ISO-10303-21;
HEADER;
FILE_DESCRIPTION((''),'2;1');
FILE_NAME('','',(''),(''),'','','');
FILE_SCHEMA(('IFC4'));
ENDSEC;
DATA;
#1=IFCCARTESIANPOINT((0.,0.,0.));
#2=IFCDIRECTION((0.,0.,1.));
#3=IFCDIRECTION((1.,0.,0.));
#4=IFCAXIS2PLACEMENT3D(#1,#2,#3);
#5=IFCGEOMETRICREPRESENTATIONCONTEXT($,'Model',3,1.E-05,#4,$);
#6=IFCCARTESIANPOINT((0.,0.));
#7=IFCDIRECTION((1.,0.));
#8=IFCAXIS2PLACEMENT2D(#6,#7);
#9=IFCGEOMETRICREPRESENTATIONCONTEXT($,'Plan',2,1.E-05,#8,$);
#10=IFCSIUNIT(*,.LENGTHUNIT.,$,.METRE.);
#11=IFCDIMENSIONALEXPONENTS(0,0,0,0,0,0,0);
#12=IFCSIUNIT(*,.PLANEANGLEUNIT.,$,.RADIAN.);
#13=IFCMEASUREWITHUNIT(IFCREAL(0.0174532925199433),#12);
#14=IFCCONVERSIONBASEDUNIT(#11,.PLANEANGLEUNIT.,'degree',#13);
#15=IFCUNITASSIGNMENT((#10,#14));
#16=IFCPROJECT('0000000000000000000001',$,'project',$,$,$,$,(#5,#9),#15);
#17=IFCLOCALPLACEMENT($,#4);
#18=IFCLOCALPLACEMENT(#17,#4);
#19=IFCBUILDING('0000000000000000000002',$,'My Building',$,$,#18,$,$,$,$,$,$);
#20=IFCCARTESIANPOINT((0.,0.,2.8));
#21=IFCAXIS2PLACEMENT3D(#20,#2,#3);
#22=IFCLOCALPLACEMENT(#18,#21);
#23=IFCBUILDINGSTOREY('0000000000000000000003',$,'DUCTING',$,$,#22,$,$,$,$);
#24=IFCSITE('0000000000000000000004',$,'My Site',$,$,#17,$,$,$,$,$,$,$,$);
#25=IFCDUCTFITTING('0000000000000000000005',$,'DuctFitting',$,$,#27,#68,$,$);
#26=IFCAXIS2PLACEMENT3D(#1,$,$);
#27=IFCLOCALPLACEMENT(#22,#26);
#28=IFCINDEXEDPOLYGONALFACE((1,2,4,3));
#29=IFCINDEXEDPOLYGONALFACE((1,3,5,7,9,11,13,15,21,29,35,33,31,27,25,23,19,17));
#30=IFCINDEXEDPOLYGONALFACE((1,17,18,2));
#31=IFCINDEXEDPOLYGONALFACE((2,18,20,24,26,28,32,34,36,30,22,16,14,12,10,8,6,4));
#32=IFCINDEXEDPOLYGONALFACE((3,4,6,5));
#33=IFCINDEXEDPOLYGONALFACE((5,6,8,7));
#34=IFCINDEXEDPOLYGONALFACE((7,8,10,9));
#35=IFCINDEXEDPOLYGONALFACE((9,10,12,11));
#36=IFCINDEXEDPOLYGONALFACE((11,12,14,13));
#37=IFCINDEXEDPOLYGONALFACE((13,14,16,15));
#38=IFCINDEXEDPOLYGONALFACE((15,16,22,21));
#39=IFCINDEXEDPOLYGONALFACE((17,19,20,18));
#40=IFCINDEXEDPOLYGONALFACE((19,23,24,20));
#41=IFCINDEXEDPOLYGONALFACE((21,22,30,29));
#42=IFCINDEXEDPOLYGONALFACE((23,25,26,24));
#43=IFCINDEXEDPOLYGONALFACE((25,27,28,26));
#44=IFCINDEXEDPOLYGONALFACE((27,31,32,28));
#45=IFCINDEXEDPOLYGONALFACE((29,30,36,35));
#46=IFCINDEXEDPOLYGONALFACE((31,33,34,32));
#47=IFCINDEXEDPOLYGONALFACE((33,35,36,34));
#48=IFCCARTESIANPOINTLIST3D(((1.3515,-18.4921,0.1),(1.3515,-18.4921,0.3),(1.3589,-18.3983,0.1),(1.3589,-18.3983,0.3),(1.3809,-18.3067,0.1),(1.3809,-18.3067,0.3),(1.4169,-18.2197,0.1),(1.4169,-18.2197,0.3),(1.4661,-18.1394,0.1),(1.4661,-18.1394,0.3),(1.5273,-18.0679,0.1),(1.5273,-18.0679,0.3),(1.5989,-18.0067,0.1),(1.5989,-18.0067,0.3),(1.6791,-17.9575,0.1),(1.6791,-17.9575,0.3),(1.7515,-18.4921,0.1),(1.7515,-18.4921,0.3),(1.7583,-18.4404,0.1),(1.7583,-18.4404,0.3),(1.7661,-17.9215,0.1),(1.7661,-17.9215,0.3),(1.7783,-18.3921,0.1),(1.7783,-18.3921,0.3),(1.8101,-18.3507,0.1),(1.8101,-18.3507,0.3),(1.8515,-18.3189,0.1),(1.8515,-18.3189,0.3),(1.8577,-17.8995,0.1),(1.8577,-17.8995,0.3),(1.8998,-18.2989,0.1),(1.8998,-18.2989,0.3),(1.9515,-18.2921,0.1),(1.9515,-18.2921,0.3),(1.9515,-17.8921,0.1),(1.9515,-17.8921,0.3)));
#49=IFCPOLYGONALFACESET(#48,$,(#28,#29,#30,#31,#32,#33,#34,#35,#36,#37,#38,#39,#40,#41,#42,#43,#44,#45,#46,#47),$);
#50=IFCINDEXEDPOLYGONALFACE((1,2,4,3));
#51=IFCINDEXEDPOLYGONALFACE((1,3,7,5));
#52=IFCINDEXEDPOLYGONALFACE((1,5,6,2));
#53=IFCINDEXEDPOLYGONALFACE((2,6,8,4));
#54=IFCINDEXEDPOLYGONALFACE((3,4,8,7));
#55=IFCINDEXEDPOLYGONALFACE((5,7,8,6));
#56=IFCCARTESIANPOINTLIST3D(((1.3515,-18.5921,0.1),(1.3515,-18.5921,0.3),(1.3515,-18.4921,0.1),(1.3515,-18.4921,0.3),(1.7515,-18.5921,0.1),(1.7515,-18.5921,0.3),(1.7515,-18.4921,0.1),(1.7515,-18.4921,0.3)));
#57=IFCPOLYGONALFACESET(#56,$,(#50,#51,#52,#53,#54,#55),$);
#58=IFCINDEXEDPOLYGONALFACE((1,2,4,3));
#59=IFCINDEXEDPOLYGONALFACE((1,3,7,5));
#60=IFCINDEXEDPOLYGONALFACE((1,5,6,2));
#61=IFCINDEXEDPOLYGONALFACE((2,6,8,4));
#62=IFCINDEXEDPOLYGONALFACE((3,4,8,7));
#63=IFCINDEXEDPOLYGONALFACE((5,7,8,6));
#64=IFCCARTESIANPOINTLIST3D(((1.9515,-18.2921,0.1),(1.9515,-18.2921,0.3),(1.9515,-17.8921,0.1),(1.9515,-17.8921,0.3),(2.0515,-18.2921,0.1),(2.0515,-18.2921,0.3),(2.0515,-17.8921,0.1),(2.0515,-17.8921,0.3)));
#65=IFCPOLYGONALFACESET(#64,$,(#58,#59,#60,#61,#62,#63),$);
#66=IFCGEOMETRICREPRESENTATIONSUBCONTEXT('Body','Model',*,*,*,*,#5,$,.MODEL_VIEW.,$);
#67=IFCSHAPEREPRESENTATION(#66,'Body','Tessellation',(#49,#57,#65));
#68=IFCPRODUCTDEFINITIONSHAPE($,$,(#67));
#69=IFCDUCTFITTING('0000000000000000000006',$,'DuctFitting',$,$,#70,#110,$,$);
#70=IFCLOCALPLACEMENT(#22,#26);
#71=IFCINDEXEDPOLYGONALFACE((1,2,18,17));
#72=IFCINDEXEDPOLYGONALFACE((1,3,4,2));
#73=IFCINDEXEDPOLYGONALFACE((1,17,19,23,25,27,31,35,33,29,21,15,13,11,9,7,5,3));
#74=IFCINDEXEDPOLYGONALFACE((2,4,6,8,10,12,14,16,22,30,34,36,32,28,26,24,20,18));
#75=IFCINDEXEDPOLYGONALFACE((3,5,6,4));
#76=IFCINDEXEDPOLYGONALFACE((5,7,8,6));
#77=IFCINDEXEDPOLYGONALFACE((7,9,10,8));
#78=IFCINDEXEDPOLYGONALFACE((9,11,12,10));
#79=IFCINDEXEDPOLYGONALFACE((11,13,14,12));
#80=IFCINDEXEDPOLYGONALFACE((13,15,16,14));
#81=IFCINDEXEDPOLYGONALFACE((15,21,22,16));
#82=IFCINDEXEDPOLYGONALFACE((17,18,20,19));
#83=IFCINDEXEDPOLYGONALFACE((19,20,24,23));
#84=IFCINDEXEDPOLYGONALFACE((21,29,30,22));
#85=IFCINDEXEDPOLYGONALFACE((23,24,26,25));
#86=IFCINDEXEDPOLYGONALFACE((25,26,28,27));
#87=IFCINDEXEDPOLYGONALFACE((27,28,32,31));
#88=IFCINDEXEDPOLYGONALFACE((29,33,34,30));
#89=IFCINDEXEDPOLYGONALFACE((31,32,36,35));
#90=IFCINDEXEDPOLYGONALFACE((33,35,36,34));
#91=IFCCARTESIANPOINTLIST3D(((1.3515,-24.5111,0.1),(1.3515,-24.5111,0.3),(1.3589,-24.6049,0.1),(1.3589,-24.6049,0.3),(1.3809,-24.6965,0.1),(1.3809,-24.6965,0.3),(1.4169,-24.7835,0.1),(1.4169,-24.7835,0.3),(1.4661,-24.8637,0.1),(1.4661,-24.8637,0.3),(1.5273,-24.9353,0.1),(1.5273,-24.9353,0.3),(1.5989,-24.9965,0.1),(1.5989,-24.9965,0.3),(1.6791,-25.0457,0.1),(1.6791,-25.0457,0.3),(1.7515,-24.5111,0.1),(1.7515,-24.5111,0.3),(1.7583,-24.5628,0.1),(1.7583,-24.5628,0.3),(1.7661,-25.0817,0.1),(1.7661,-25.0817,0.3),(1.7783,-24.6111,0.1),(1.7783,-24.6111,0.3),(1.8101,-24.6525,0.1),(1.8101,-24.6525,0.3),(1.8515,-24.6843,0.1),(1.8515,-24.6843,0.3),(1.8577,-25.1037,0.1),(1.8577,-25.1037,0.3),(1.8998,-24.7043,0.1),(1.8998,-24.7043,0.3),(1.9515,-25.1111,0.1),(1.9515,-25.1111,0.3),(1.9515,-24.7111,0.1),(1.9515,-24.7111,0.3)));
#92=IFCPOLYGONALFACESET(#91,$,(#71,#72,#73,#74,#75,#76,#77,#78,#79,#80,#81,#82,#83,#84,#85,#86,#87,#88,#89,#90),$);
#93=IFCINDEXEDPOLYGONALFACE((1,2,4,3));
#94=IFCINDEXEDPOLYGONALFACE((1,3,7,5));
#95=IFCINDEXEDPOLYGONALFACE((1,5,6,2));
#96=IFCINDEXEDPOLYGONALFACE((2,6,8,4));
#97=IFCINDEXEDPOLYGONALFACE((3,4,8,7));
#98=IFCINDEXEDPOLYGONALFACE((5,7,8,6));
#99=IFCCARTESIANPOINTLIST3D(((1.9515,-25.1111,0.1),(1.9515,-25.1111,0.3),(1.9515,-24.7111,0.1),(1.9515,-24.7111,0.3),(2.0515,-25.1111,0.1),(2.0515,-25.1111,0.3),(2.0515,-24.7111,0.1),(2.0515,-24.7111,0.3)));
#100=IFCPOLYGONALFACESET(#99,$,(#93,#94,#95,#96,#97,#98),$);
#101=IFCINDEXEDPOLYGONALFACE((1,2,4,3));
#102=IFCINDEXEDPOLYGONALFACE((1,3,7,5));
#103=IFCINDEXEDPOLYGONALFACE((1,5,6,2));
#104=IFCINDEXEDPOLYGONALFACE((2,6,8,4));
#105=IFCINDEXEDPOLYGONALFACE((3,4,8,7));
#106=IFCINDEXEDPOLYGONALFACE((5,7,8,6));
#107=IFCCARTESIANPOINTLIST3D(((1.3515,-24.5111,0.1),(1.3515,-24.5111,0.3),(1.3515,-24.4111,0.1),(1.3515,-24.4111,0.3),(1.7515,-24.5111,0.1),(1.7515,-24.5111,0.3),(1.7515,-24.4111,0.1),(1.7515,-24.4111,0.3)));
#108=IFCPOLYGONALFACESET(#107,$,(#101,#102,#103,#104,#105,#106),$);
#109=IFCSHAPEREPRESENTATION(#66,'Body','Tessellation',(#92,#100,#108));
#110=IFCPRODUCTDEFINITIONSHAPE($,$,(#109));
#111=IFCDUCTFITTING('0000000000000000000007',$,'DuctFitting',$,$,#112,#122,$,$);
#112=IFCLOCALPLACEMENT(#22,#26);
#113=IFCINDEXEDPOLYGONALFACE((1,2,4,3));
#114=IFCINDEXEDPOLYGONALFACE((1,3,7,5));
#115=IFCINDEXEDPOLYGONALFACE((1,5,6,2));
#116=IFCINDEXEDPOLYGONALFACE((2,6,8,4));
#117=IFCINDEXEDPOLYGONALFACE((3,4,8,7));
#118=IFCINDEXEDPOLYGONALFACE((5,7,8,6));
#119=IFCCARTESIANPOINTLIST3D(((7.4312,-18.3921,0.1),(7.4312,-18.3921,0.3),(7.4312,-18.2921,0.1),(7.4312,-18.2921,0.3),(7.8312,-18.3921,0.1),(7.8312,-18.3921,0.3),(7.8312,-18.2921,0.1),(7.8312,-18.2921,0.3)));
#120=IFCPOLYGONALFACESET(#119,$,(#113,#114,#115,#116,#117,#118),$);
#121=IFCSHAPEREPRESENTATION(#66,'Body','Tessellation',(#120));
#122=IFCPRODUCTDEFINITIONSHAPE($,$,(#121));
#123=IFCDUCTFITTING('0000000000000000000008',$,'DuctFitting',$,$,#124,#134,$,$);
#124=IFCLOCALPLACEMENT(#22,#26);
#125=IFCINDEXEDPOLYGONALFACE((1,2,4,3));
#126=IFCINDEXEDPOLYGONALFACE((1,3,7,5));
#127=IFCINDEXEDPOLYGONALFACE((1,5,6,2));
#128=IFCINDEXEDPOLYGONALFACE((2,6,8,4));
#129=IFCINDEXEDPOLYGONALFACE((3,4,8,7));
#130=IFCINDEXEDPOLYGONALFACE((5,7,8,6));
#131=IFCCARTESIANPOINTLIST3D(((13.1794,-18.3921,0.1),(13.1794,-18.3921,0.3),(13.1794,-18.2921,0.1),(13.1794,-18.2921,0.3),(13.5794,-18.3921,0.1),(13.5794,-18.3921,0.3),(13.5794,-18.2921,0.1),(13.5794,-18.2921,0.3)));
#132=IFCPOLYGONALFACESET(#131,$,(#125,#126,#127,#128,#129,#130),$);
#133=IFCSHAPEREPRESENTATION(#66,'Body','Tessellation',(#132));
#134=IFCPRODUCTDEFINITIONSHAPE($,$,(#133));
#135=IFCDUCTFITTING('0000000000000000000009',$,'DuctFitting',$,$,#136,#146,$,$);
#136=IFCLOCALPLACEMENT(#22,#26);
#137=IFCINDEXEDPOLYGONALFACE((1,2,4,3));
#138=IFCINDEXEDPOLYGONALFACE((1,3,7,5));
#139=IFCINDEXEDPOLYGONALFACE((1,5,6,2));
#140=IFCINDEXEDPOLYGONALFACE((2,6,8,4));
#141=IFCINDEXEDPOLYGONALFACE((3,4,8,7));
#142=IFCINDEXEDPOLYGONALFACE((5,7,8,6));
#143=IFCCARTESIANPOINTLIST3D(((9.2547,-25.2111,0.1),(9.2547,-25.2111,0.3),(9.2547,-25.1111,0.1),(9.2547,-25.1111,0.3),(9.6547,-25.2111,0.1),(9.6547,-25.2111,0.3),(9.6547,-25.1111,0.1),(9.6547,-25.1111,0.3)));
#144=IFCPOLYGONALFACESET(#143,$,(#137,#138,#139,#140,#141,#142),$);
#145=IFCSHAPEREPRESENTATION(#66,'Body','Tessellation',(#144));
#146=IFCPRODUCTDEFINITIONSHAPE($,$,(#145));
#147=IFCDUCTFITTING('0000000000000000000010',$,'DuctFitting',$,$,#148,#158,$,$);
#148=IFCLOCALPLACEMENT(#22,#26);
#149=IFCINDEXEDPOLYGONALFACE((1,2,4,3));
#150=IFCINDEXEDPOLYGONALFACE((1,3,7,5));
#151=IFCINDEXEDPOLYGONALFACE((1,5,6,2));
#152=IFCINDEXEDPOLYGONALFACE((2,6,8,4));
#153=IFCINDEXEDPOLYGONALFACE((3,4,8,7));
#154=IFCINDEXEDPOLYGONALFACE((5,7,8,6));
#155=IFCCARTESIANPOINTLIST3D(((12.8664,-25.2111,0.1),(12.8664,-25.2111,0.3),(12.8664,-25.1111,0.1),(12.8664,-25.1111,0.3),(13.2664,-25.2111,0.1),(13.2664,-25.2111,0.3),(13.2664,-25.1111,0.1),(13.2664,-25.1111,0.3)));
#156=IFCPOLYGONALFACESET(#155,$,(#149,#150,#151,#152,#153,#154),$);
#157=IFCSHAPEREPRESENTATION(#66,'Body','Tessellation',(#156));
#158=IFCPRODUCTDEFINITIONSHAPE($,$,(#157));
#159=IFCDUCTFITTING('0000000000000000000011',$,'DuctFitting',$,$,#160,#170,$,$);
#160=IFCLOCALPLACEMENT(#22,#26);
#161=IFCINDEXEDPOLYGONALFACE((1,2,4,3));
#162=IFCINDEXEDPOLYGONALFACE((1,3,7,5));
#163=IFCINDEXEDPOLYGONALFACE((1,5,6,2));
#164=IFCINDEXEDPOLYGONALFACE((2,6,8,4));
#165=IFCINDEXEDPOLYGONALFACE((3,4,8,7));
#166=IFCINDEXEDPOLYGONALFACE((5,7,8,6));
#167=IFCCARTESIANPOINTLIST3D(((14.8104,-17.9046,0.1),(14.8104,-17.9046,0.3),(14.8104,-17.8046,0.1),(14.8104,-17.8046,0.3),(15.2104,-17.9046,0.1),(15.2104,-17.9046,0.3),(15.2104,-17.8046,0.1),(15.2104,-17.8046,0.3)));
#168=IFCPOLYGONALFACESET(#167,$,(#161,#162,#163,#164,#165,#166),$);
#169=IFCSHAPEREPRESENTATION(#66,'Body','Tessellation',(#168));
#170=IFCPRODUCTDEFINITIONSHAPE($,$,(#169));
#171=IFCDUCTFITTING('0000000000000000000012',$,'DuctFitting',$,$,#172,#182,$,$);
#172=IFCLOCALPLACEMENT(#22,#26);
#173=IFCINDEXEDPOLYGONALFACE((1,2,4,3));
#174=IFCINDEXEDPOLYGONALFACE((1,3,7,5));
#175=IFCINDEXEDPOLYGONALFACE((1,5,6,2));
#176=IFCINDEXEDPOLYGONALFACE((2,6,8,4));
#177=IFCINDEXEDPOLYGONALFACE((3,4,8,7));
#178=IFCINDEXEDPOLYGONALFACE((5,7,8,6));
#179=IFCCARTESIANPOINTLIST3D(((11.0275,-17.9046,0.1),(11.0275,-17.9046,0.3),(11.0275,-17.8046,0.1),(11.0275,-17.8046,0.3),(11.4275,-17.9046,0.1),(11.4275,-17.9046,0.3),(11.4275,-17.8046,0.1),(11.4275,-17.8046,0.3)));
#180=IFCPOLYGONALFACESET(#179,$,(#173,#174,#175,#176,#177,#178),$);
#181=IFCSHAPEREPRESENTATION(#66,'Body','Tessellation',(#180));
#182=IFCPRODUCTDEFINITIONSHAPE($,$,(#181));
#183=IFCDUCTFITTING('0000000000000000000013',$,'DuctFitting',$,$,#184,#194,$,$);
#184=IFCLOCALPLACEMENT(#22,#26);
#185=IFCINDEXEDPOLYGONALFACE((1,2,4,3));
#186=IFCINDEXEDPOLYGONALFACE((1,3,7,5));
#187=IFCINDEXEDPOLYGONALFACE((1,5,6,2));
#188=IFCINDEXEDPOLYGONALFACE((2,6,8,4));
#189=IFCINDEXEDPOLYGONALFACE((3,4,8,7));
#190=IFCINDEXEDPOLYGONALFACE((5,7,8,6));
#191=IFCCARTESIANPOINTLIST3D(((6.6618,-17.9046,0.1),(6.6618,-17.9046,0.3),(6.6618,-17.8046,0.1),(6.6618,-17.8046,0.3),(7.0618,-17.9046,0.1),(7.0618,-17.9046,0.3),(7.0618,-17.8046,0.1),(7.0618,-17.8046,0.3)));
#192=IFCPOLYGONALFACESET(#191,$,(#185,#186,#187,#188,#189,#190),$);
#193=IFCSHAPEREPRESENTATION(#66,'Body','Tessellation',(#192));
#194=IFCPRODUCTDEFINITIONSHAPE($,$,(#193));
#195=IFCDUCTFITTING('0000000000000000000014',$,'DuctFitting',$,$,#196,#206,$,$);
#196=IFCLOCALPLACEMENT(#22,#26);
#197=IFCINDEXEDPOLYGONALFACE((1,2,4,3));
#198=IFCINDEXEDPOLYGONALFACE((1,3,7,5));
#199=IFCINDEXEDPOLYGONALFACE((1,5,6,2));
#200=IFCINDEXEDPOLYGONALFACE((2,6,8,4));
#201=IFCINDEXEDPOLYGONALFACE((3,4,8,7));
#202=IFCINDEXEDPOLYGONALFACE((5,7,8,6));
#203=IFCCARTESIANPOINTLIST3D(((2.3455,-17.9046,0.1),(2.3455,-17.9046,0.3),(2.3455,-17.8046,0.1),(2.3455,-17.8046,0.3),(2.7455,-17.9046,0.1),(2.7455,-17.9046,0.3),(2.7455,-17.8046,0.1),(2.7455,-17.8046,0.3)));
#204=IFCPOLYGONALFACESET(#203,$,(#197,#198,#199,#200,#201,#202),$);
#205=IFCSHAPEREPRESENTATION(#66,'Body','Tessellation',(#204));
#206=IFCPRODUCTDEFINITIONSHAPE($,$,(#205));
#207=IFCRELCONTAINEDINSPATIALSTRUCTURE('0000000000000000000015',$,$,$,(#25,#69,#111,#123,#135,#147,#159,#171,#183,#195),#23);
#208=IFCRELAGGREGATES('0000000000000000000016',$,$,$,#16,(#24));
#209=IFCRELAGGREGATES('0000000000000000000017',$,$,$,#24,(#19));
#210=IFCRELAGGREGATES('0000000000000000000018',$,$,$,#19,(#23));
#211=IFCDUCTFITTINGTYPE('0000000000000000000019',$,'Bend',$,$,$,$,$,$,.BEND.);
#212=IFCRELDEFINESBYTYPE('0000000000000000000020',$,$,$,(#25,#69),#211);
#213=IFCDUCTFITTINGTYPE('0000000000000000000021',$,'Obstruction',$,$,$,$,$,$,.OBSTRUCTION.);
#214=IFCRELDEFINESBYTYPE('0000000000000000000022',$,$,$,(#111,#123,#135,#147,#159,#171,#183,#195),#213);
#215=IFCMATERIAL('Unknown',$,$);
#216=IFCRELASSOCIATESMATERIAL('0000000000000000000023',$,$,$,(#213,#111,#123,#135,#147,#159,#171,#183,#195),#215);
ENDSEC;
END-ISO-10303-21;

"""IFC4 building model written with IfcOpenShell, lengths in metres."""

from ifc_helpers import new_model, entity, si_unit, converted_unit, frame, origin_with_axes, origin_2d_with_axis, place, context, subcontext, project, spatial, line, arc, indexed_curve, rectangle, outline, extrude, source, transform, mapped, material, material_profile, profile_set, profile_usage, type_object, type_shapes, element, save


model = new_model("IFC4")

# Units and contexts
model_context = context("Model", 3, precision=1e-05, world=origin_with_axes())
plan_context = context("Plan", 2, precision=1e-05, world=origin_2d_with_axis())
body_context = subcontext(model_context, "Body", "Model", "MODEL_VIEW")
ifc_project = project(units=[si_unit("LENGTHUNIT", "METRE"), converted_unit("PLANEANGLEUNIT", "degree", entity("IfcReal", 0.0174532925199433), si_unit("PLANEANGLEUNIT", "RADIAN"), dimensions=[0, 0, 0, 0, 0, 0, 0])], contexts=[model_context, plan_context])

# Site, building, storey
site_placement = place(None, origin_with_axes())
site = spatial("IfcSite", under=ifc_project, at=site_placement, Name="My Site")
building_placement = place(site_placement, origin_with_axes())
building = spatial("IfcBuilding", under=site, at=building_placement, Name="My Building")
storey_placement = place(building_placement, frame((0.0, 0.0, 2.8), z_axis=(0.0, 0.0, 1.0), x_axis=(1.0, 0.0, 0.0)))
storey = spatial("IfcBuildingStorey", under=building, at=storey_placement, Name="DUCTING")

# Shared definitions
ifc_material = material(Name="Unknown")

# Duct fittings
duct_fitting_type_1 = type_object("IfcDuctFittingType", Name="Bend", PredefinedType="BEND")
shared_shape = source(origin_with_axes(), body_context, "Body", "SweptSolid", [
    extrude(outline(indexed_curve([(-0.2, 0.0), (-0.2586, -0.1414), (-0.4, -0.2), (-0.4, -0.6), (0.0243, -0.4243), (0.2, 0.0)], segments=[arc(1, 2, 3), line(3, 4), arc(4, 5, 6), line(6, 1)])), frame((0.0, -0.1, -0.1), z_axis=(0.0, -1.0, 0.0), x_axis=(1.0, 0.0, 0.0)), (0.0, 0.0, -1.0), 0.2),
    extrude(rectangle(XDim=0.4, YDim=0.2), origin_with_axes(), (0.0, 0.0, -1.0), 0.1),
    extrude(rectangle(XDim=0.4, YDim=0.2), frame((-0.4, 0.0, -0.5), z_axis=(-1.0, 0.0, 0.0), x_axis=(0.0, 0.0, -1.0)), (0.0, 0.0, 1.0), 0.1),
])
type_shapes(duct_fitting_type_1, [shared_shape])
for number, where, z_axis, x_axis, name in (
    (1, (1.5515, -18.5921, 0.2), (0.0, -1.0, 0.0), (-1.0, 0.0, 0.0), "DuctFitting"),
    (2, (2.0515, -24.9111, 0.2), (1.0, 0.0, 0.0), (0.0, -1.0, 0.0), "DuctFitting"),
):
    element("IfcDuctFitting", number, at=place(storey_placement, frame(where, z_axis=z_axis, x_axis=x_axis)), inside=storey, type_object=duct_fitting_type_1, Name=name, context=body_context, shape_type="MappedRepresentation", body=[
        mapped(shared_shape, transform((0.0, 0.0, 0.0), x_axis=(1.0, 0.0, 0.0), y_axis=(0.0, 1.0, 0.0), z_axis=(0.0, 0.0, 1.0), scale=1.0)),
    ])
ifc_material_profile_1 = material_profile(ifc_material, rectangle(XDim=0.4, YDim=0.2))
ifc_profile_set_1 = profile_set([ifc_material_profile_1])
ifc_profile_usage_1 = profile_usage(ifc_profile_set_1, cardinal=5)
duct_fitting_type_2 = type_object("IfcDuctFittingType", Name="Obstruction", PredefinedType="OBSTRUCTION", material=ifc_profile_set_1)
duct_fitting_1_placement = place(storey_placement, frame((7.6312, -18.2921, 0.2), z_axis=(0.0, -1.0, 0.0), x_axis=(1.0, 0.0, 0.0)))
element("IfcDuctFitting", 3, at=duct_fitting_1_placement, inside=storey, type_object=duct_fitting_type_2, material=ifc_profile_usage_1, Name="DuctFitting", context=body_context, shape_type="SweptSolid", body=[
    extrude(rectangle(XDim=0.4, YDim=0.2), origin_with_axes(), (0.0, 0.0, 1.0), 0.1),
])
ifc_profile_usage_2 = profile_usage(ifc_profile_set_1, cardinal=5)
duct_fitting_2_placement = place(storey_placement, frame((13.3794, -18.2921, 0.2), z_axis=(0.0, -1.0, 0.0), x_axis=(1.0, 0.0, 0.0)))
element("IfcDuctFitting", 4, at=duct_fitting_2_placement, inside=storey, type_object=duct_fitting_type_2, material=ifc_profile_usage_2, Name="DuctFitting", context=body_context, shape_type="SweptSolid", body=[
    extrude(rectangle(XDim=0.4, YDim=0.2), origin_with_axes(), (0.0, 0.0, 1.0), 0.1),
])
ifc_profile_usage_3 = profile_usage(ifc_profile_set_1, cardinal=5)
duct_fitting_3_placement = place(storey_placement, frame((9.4547, -25.1111, 0.2), z_axis=(0.0, -1.0, 0.0), x_axis=(1.0, 0.0, 0.0)))
element("IfcDuctFitting", 5, at=duct_fitting_3_placement, inside=storey, type_object=duct_fitting_type_2, material=ifc_profile_usage_3, Name="DuctFitting", context=body_context, shape_type="SweptSolid", body=[
    extrude(rectangle(XDim=0.4, YDim=0.2), origin_with_axes(), (0.0, 0.0, 1.0), 0.1),
])
ifc_profile_usage_4 = profile_usage(ifc_profile_set_1, cardinal=5)
duct_fitting_4_placement = place(storey_placement, frame((13.0664, -25.1111, 0.2), z_axis=(0.0, -1.0, 0.0), x_axis=(1.0, 0.0, 0.0)))
element("IfcDuctFitting", 6, at=duct_fitting_4_placement, inside=storey, type_object=duct_fitting_type_2, material=ifc_profile_usage_4, Name="DuctFitting", context=body_context, shape_type="SweptSolid", body=[
    extrude(rectangle(XDim=0.4, YDim=0.2), origin_with_axes(), (0.0, 0.0, 1.0), 0.1),
])
ifc_profile_usage_5 = profile_usage(ifc_profile_set_1, cardinal=5)
duct_fitting_5_placement = place(storey_placement, frame((15.0104, -17.9046, 0.2), z_axis=(0.0, 1.0, 0.0), x_axis=(-1.0, 0.0, 0.0)))
element("IfcDuctFitting", 7, at=duct_fitting_5_placement, inside=storey, type_object=duct_fitting_type_2, material=ifc_profile_usage_5, Name="DuctFitting", context=body_context, shape_type="SweptSolid", body=[
    extrude(rectangle(XDim=0.4, YDim=0.2), origin_with_axes(), (0.0, 0.0, 1.0), 0.1),
])
ifc_profile_usage_6 = profile_usage(ifc_profile_set_1, cardinal=5)
duct_fitting_6_placement = place(storey_placement, frame((11.2275, -17.9046, 0.2), z_axis=(0.0, 1.0, 0.0), x_axis=(-1.0, 0.0, 0.0)))
element("IfcDuctFitting", 8, at=duct_fitting_6_placement, inside=storey, type_object=duct_fitting_type_2, material=ifc_profile_usage_6, Name="DuctFitting", context=body_context, shape_type="SweptSolid", body=[
    extrude(rectangle(XDim=0.4, YDim=0.2), origin_with_axes(), (0.0, 0.0, 1.0), 0.1),
])
ifc_profile_usage_7 = profile_usage(ifc_profile_set_1, cardinal=5)
duct_fitting_7_placement = place(storey_placement, frame((6.8618, -17.9046, 0.2), z_axis=(0.0, 1.0, 0.0), x_axis=(-1.0, 0.0, 0.0)))
element("IfcDuctFitting", 9, at=duct_fitting_7_placement, inside=storey, type_object=duct_fitting_type_2, material=ifc_profile_usage_7, Name="DuctFitting", context=body_context, shape_type="SweptSolid", body=[
    extrude(rectangle(XDim=0.4, YDim=0.2), origin_with_axes(), (0.0, 0.0, 1.0), 0.1),
])
ifc_profile_usage_8 = profile_usage(ifc_profile_set_1, cardinal=5)
duct_fitting_8_placement = place(storey_placement, frame((2.5455, -17.9046, 0.2), z_axis=(0.0, 1.0, 0.0), x_axis=(-1.0, 0.0, 0.0)))
element("IfcDuctFitting", 10, at=duct_fitting_8_placement, inside=storey, type_object=duct_fitting_type_2, material=ifc_profile_usage_8, Name="DuctFitting", context=body_context, shape_type="SweptSolid", body=[
    extrude(rectangle(XDim=0.4, YDim=0.2), origin_with_axes(), (0.0, 0.0, 1.0), 0.1),
])

save(model, "model.ifc")
